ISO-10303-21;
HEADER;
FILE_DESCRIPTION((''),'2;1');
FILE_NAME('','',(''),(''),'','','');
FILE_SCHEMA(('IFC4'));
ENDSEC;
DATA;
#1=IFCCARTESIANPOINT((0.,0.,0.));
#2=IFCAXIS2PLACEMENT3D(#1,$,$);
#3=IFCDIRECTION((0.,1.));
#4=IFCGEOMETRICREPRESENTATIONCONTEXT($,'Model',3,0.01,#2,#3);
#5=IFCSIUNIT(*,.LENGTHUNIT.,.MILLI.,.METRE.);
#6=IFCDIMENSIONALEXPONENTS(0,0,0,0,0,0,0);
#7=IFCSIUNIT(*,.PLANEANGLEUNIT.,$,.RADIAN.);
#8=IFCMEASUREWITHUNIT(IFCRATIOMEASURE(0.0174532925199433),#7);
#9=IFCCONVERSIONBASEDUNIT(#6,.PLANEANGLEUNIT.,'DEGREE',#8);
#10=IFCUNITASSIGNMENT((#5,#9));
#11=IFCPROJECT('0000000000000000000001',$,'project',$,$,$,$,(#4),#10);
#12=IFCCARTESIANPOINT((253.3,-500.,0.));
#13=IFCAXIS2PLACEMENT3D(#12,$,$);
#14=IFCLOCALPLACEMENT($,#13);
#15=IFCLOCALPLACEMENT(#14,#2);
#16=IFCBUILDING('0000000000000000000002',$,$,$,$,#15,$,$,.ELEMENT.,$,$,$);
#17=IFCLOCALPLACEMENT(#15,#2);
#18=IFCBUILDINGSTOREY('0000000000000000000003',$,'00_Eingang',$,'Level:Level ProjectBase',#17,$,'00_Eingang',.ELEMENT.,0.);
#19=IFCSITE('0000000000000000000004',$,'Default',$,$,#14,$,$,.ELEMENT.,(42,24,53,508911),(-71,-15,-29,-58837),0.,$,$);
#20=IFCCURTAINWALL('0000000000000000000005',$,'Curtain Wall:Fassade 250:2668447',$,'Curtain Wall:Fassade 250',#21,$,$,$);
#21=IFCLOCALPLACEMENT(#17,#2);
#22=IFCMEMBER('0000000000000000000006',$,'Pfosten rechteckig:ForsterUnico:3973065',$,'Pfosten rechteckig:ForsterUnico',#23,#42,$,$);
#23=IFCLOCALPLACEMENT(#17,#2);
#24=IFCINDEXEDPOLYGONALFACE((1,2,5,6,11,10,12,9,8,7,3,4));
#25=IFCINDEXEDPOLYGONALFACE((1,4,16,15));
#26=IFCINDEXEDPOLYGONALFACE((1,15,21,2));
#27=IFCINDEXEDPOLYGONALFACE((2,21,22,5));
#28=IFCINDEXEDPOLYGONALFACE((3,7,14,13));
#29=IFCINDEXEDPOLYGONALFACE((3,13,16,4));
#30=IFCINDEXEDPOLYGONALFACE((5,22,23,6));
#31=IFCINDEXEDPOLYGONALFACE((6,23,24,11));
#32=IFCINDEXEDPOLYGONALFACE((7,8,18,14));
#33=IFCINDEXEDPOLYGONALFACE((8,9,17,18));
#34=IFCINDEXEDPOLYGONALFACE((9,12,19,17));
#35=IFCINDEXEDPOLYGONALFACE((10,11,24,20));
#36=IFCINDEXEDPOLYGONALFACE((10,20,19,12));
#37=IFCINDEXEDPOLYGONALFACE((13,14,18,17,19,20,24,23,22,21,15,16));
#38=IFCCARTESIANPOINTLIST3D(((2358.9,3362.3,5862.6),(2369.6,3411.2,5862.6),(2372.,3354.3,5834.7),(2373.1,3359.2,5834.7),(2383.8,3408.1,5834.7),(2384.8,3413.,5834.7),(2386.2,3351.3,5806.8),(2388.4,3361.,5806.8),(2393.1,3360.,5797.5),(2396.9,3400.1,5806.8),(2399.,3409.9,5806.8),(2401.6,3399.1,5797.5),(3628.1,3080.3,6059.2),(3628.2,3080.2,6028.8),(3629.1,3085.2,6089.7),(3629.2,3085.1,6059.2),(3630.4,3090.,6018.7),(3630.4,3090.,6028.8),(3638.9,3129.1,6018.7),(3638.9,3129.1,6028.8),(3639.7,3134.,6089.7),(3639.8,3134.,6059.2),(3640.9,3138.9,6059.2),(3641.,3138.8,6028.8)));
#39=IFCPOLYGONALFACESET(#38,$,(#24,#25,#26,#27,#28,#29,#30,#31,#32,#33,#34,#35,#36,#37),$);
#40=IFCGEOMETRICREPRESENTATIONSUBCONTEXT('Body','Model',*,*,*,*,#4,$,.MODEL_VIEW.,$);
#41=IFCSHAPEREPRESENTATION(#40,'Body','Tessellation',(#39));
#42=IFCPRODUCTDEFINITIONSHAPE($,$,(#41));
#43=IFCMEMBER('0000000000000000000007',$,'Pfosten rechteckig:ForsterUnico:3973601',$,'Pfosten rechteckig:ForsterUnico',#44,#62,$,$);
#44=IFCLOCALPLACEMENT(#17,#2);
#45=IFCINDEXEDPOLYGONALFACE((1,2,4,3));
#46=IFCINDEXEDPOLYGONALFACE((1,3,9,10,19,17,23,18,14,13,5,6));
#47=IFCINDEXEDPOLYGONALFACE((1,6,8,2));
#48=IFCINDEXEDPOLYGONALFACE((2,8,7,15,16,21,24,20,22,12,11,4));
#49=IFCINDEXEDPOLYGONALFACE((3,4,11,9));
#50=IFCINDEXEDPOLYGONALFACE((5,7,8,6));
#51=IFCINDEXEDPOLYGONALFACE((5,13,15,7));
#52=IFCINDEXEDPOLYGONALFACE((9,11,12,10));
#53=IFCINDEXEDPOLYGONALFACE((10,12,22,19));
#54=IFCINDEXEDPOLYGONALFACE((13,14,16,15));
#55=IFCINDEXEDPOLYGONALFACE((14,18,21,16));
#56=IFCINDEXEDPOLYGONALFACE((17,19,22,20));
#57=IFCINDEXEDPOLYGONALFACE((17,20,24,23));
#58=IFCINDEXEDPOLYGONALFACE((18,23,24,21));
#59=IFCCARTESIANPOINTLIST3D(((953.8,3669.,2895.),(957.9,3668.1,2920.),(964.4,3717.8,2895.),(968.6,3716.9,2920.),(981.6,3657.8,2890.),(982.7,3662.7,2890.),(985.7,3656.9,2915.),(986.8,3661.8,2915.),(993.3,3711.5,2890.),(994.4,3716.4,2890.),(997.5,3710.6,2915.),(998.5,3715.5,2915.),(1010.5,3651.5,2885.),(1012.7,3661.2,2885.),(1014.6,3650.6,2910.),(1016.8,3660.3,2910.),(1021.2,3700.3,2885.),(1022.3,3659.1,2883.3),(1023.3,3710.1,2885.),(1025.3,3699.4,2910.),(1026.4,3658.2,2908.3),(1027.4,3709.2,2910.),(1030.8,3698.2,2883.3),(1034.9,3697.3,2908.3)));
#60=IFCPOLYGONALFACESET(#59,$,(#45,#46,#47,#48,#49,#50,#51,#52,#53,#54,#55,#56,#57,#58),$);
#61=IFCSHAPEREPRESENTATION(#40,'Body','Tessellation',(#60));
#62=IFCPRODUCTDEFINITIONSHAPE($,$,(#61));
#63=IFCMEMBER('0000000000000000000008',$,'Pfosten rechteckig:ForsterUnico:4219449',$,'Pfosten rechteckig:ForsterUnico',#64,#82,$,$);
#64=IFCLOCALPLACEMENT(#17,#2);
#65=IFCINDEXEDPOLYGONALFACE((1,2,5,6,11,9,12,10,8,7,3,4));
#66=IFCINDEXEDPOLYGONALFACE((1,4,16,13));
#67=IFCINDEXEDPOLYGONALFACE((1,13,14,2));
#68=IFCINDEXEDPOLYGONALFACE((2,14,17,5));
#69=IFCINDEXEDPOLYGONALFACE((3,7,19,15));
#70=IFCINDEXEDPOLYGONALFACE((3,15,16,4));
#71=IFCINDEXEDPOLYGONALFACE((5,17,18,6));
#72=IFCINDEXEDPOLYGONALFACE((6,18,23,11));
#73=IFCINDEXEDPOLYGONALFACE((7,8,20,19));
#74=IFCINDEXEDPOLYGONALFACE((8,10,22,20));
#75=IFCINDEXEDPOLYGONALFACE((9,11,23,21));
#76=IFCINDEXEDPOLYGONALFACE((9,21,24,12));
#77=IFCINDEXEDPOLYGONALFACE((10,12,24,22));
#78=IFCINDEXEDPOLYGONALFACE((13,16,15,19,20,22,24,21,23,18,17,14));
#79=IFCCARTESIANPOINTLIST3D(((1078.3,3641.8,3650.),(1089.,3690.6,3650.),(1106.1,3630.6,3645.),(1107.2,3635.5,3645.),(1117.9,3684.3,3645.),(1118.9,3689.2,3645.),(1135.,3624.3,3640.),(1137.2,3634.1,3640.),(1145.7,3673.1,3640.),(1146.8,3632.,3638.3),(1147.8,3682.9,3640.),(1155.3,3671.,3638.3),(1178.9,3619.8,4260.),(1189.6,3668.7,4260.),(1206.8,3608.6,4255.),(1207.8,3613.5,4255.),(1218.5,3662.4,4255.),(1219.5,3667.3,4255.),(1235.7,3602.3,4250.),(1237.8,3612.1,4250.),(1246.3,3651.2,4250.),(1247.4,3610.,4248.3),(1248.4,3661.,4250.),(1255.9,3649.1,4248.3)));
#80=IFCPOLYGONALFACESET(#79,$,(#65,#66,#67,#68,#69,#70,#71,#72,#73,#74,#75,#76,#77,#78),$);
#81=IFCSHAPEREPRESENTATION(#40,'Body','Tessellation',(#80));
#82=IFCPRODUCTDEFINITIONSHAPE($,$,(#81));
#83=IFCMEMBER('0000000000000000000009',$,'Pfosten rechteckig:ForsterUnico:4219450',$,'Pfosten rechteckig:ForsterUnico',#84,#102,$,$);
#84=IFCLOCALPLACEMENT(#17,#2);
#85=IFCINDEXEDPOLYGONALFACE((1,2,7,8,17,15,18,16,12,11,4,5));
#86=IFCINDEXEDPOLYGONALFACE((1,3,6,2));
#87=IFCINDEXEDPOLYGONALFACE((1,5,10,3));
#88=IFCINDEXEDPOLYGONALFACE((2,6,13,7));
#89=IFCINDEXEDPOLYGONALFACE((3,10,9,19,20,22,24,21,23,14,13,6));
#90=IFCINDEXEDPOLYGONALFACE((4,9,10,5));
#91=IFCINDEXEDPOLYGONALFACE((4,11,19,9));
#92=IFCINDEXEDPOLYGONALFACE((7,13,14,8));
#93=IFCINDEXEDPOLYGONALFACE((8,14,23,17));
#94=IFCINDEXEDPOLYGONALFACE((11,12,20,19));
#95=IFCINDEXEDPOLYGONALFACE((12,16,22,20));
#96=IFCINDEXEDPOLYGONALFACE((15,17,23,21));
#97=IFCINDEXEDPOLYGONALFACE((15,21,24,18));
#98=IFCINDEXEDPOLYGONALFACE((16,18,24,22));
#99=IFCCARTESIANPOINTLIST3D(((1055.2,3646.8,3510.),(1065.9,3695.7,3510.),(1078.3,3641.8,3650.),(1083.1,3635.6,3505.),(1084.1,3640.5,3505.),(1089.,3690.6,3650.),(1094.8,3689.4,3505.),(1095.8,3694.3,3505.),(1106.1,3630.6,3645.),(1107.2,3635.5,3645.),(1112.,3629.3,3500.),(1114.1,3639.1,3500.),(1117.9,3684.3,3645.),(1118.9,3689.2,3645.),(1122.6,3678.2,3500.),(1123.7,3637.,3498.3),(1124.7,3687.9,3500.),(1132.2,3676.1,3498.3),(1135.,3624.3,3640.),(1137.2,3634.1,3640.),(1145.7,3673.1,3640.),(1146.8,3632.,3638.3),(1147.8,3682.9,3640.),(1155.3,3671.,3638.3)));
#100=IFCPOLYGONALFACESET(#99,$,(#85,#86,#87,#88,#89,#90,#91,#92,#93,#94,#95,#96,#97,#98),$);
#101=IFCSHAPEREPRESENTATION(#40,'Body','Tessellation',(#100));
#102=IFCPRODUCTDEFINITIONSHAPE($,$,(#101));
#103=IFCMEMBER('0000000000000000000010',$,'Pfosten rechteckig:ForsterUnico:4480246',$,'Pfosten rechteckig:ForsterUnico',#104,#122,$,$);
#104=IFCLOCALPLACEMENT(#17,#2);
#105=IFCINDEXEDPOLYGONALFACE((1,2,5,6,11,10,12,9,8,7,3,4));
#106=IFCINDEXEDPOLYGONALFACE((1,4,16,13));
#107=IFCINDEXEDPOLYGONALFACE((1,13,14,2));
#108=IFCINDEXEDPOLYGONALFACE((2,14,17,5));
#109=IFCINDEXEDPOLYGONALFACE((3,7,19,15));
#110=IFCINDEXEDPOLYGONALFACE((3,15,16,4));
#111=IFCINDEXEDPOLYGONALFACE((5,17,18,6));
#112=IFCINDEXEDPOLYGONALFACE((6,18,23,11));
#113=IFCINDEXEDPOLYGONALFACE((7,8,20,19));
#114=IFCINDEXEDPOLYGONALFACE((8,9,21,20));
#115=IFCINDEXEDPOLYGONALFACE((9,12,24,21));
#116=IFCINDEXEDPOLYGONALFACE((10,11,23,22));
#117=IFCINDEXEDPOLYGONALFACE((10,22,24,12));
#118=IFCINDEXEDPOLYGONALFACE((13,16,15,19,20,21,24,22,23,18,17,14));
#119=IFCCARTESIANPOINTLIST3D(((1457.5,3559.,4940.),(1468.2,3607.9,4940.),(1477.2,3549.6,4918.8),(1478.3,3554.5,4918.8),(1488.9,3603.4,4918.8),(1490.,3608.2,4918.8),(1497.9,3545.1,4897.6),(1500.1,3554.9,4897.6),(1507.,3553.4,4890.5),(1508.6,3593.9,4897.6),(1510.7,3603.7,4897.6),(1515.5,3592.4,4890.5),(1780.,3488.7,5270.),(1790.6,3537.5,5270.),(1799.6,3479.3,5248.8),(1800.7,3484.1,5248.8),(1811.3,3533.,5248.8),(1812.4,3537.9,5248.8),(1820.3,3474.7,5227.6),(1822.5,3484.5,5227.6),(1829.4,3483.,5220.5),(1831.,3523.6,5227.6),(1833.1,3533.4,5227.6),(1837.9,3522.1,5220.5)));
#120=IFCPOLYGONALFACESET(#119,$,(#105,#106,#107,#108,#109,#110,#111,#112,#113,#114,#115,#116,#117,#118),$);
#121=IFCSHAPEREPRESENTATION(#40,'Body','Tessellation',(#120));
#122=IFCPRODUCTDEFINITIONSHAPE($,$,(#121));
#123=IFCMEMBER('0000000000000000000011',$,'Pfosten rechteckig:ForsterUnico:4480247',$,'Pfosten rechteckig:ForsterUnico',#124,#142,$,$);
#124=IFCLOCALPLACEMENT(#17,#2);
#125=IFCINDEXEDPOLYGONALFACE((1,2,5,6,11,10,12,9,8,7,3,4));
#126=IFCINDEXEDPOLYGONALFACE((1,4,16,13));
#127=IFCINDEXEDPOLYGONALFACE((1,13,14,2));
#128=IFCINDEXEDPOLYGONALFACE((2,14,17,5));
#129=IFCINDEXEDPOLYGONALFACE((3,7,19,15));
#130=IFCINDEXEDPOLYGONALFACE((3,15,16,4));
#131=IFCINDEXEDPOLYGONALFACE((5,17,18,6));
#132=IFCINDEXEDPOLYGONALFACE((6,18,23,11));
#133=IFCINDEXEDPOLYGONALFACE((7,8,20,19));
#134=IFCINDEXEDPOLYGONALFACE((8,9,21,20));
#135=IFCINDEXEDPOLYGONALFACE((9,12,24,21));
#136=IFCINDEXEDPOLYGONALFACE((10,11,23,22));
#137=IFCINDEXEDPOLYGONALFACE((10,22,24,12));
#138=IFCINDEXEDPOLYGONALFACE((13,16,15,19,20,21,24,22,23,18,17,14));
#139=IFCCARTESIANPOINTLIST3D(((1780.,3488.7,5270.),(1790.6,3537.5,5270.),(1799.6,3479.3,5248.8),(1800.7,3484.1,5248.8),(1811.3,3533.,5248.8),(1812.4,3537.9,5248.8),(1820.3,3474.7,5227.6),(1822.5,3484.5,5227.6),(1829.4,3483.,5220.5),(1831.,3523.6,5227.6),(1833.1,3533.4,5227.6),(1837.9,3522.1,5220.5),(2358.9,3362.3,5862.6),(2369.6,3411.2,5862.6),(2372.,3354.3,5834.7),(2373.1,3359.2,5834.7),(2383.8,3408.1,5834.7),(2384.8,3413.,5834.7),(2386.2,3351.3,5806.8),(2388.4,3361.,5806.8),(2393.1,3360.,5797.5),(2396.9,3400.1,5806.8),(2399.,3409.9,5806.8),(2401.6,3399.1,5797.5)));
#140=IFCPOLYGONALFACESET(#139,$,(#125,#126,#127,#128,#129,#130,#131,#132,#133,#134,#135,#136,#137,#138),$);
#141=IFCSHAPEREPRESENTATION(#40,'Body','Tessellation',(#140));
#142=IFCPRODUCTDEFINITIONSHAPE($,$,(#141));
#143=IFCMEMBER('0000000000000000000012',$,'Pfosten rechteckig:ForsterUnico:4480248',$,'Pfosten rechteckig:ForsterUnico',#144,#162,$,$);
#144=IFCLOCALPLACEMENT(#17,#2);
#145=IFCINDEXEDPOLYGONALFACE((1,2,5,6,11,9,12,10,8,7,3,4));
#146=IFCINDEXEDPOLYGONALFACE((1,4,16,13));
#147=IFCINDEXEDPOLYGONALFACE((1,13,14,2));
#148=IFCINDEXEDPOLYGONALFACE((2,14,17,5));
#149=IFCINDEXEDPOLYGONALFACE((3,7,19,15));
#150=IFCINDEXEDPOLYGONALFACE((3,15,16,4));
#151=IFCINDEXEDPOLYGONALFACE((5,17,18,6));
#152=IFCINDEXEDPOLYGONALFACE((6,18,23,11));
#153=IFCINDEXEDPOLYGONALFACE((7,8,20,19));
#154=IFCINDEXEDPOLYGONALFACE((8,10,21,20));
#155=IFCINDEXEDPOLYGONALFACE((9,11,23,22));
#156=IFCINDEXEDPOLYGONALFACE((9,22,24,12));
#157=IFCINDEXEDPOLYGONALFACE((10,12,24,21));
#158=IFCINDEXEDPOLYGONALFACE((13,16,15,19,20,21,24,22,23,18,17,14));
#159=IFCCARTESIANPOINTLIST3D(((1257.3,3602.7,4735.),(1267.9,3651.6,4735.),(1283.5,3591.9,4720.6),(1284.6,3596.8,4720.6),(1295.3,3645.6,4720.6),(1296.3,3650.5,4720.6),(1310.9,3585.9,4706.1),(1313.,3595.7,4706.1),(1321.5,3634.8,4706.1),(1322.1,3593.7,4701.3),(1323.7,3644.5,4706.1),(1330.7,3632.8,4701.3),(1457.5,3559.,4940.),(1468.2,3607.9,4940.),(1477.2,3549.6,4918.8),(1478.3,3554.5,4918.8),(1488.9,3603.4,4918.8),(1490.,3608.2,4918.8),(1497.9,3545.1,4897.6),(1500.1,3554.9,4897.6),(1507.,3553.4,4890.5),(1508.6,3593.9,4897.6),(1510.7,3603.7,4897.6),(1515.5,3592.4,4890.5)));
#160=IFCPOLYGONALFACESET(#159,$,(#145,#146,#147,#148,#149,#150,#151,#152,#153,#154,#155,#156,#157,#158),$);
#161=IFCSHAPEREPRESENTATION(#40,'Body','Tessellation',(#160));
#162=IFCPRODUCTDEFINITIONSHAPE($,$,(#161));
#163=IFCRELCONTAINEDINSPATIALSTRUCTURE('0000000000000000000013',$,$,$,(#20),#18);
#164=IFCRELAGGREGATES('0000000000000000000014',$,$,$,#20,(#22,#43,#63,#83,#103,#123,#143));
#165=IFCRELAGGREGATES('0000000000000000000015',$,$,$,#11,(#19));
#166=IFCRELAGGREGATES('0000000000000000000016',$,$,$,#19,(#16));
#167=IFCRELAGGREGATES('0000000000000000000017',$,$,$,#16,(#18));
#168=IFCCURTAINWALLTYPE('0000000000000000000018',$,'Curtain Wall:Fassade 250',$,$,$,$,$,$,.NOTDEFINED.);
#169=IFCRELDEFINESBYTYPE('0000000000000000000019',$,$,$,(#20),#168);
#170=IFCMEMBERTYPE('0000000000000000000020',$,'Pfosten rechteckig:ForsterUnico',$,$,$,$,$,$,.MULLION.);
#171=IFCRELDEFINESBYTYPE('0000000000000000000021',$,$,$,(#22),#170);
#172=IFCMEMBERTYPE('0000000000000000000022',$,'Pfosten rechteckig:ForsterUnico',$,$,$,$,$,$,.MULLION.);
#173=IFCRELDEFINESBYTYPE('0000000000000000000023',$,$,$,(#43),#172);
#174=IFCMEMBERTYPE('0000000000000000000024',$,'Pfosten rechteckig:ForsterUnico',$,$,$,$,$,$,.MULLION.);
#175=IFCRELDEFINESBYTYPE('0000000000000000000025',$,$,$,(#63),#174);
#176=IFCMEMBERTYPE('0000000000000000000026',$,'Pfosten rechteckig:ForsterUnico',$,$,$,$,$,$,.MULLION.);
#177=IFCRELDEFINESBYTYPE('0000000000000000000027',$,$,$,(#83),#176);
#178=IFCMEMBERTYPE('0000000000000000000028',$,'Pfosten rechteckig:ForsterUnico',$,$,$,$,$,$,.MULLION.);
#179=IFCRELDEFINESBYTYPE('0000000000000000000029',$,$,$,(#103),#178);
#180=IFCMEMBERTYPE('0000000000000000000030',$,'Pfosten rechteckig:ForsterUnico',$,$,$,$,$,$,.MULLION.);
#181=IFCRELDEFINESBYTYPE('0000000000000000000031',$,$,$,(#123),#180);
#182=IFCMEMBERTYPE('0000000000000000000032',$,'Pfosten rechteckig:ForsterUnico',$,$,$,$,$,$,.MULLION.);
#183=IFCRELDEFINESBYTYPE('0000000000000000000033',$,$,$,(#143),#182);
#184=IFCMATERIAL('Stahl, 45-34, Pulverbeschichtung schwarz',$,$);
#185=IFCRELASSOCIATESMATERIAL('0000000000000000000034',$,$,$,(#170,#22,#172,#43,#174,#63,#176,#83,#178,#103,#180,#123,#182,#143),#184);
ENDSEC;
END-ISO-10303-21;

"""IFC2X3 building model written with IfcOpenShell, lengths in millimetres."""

from ifc_helpers import new_model, entity, si_unit, converted_unit, direction, frame, origin, place, context, subcontext, project, spatial, polyline, outline, extrude, clip, halfspace, source, transform, mapped, material, type_object, type_shapes, element, aggregate, save


model = new_model("IFC2X3")

# Units and contexts
model_context = context("Model", 3, precision=0.01, world=origin(), true_north=direction((0.0, 1.0)))
body_context = subcontext(model_context, "Body", "Model", "MODEL_VIEW")
ifc_project = project(units=[si_unit("LENGTHUNIT", "METRE", prefix="MILLI"), converted_unit("PLANEANGLEUNIT", "DEGREE", entity("IfcRatioMeasure", 0.0174532925199433), si_unit("PLANEANGLEUNIT", "RADIAN"), dimensions=[0, 0, 0, 0, 0, 0, 0])], contexts=[model_context])

# Site, building, storey
site_placement = place(None, frame((253.3, -500.0, 0.0)))
site = spatial("IfcSite", under=ifc_project, at=site_placement, Name="Default", CompositionType="ELEMENT", RefLatitude=(42, 24, 53, 508911), RefLongitude=(-71, -15, -29, -58837), RefElevation=0.0)
building_placement = place(site_placement, origin())
building = spatial("IfcBuilding", under=site, at=building_placement, CompositionType="ELEMENT")
storey_placement = place(building_placement, origin())
storey = spatial("IfcBuildingStorey", under=building, at=storey_placement, Name="00_Eingang", ObjectType="Level:Level ProjectBase", LongName="00_Eingang", CompositionType="ELEMENT", Elevation=0.0)

# Curtain wall, members
curtain_wall_type = type_object("IfcCurtainWallType", Name="Curtain Wall:Fassade 250", PredefinedType="NOTDEFINED")
curtain_wall_placement = place(storey_placement, origin())
curtain_wall = element("IfcCurtainWall", 1, at=curtain_wall_placement, inside=storey, type_object=curtain_wall_type, Name="Curtain Wall:Fassade 250:2668447", ObjectType="Curtain Wall:Fassade 250")
ifc_material_1 = material(Name="Stahl, 45-34, Pulverbeschichtung schwarz")
member_type_1 = type_object("IfcMemberType", Name="Pfosten rechteckig:ForsterUnico", PredefinedType="MULLION", material=ifc_material_1)
shared_shape_1 = source(origin(), body_context, "Body", "Clipping", [
    clip(clip(extrude(outline(polyline([(-20.0, -28.3), (20.0, -28.3), (20.0, -18.3), (30.0, -18.3), (30.0, 11.7), (25.0, 11.7), (25.0, 41.7), (-25.0, 41.7), (-25.0, 11.7), (-30.0, 11.7), (-30.0, -18.3), (-20.0, -18.3), (-20.0, -28.3)])), frame((-41.7, 0.0, -1319.7), z_axis=(0.0, 0.0, 1.0), x_axis=(0.0, -1.0, 0.0)), (0.0, 0.0, 1.0), 1319.7), halfspace(frame((0.0, -304.8, -1319.7), z_axis=(-0.167911, 0.0, -0.985802), x_axis=(-0.985802, 0.0, 0.167911)), False)), halfspace(frame((0.0, -304.8, 0.0), z_axis=(-0.301476, 0.0, 0.953474), x_axis=(-0.953474, 0.0, -0.301476)), False)),
])
type_shapes(member_type_1, [shared_shape_1])
member_1_placement = place(storey_placement, frame((2364.3, 3386.8, 5862.6), z_axis=(-0.962438, 0.210021, -0.172057), x_axis=(-0.168101, 0.036683, 0.985087)))
member_1 = element("IfcMember", 2, at=member_1_placement, type_object=member_type_1, material=ifc_material_1, Name="Pfosten rechteckig:ForsterUnico:3973065", ObjectType="Pfosten rechteckig:ForsterUnico", context=body_context, shape_type="MappedRepresentation", body=[
    mapped(shared_shape_1, transform((0.0, 0.0, 0.0), scale=1.0)),
])
member_type_2 = type_object("IfcMemberType", Name="Pfosten rechteckig:ForsterUnico", PredefinedType="MULLION", material=ifc_material_1)
shared_shape_2 = source(origin(), body_context, "Body", "SweptSolid", [
    extrude(outline(polyline([(-20.0, -28.3), (20.0, -28.3), (20.0, -18.3), (30.0, -18.3), (30.0, 11.7), (25.0, 11.7), (25.0, 41.7), (-25.0, 41.7), (-25.0, 11.7), (-30.0, 11.7), (-30.0, -18.3), (-20.0, -18.3), (-20.0, -28.3)])), frame((-41.7, 0.0, -25.4), z_axis=(0.0, 0.0, 1.0), x_axis=(0.0, -1.0, 0.0)), (0.0, 0.0, 1.0), 25.4),
])
type_shapes(member_type_2, [shared_shape_2])
member_2_placement = place(storey_placement, frame((959.1, 3693.4, 2895.0), z_axis=(-0.162632, 0.035489, -0.986048), x_axis=(-0.963377, 0.210226, 0.16646)))
member_2 = element("IfcMember", 3, at=member_2_placement, type_object=member_type_2, material=ifc_material_1, Name="Pfosten rechteckig:ForsterUnico:3973601", ObjectType="Pfosten rechteckig:ForsterUnico", context=body_context, shape_type="MappedRepresentation", body=[
    mapped(shared_shape_2, transform((0.0, 0.0, 0.0), scale=1.0)),
])
member_type_3 = type_object("IfcMemberType", Name="Pfosten rechteckig:ForsterUnico", PredefinedType="MULLION", material=ifc_material_1)
shared_shape_3 = source(origin(), body_context, "Body", "SweptSolid", [
    extrude(outline(polyline([(-20.0, -28.3), (20.0, -28.3), (20.0, -18.3), (30.0, -18.3), (30.0, 11.7), (25.0, 11.7), (25.0, 41.7), (-25.0, 41.7), (-25.0, 11.7), (-30.0, 11.7), (-30.0, -18.3), (-20.0, -18.3), (-20.0, -28.3)])), frame((-41.7, 0.0, -618.6), z_axis=(0.0, 0.0, 1.0), x_axis=(0.0, -1.0, 0.0)), (0.0, 0.0, 1.0), 618.6),
])
type_shapes(member_type_3, [shared_shape_3])
member_3_placement = place(storey_placement, frame((1083.6, 3666.2, 3650.0), z_axis=(-0.162632, 0.035489, -0.986048), x_axis=(-0.963377, 0.210226, 0.16646)))
member_3 = element("IfcMember", 4, at=member_3_placement, type_object=member_type_3, material=ifc_material_1, Name="Pfosten rechteckig:ForsterUnico:4219449", ObjectType="Pfosten rechteckig:ForsterUnico", context=body_context, shape_type="MappedRepresentation", body=[
    mapped(shared_shape_3, transform((0.0, 0.0, 0.0), scale=1.0)),
])
member_type_4 = type_object("IfcMemberType", Name="Pfosten rechteckig:ForsterUnico", PredefinedType="MULLION", material=ifc_material_1)
shared_shape_4 = source(origin(), body_context, "Body", "SweptSolid", [
    extrude(outline(polyline([(-20.0, -28.3), (20.0, -28.3), (20.0, -18.3), (30.0, -18.3), (30.0, 11.7), (25.0, 11.7), (25.0, 41.7), (-25.0, 41.7), (-25.0, 11.7), (-30.0, 11.7), (-30.0, -18.3), (-20.0, -18.3), (-20.0, -28.3)])), frame((-41.7, 0.0, -142.0), z_axis=(0.0, 0.0, 1.0), x_axis=(0.0, -1.0, 0.0)), (0.0, 0.0, 1.0), 142.0),
])
type_shapes(member_type_4, [shared_shape_4])
member_4_placement = place(storey_placement, frame((1060.5, 3671.2, 3510.0), z_axis=(-0.162632, 0.035489, -0.986048), x_axis=(-0.963377, 0.210226, 0.16646)))
member_4 = element("IfcMember", 5, at=member_4_placement, type_object=member_type_4, material=ifc_material_1, Name="Pfosten rechteckig:ForsterUnico:4219450", ObjectType="Pfosten rechteckig:ForsterUnico", context=body_context, shape_type="MappedRepresentation", body=[
    mapped(shared_shape_4, transform((0.0, 0.0, 0.0), scale=1.0)),
])
member_type_5 = type_object("IfcMemberType", Name="Pfosten rechteckig:ForsterUnico", PredefinedType="MULLION", material=ifc_material_1)
shared_shape_5 = source(origin(), body_context, "Body", "SweptSolid", [
    extrude(outline(polyline([(-20.0, -28.3), (20.0, -28.3), (20.0, -18.3), (30.0, -18.3), (30.0, 11.7), (25.0, 11.7), (25.0, 41.7), (-25.0, 41.7), (-25.0, 11.7), (-30.0, 11.7), (-30.0, -18.3), (-20.0, -18.3), (-20.0, -28.3)])), frame((-41.7, 0.0, -466.7), z_axis=(0.0, 0.0, 1.0), x_axis=(0.0, -1.0, 0.0)), (0.0, 0.0, 1.0), 466.7),
])
type_shapes(member_type_5, [shared_shape_5])
member_5_placement = place(storey_placement, frame((1462.9, 3583.5, 4940.0), z_axis=(-0.690849, 0.150756, -0.707107), x_axis=(-0.690849, 0.150756, 0.707107)))
member_5 = element("IfcMember", 6, at=member_5_placement, type_object=member_type_5, material=ifc_material_1, Name="Pfosten rechteckig:ForsterUnico:4480246", ObjectType="Pfosten rechteckig:ForsterUnico", context=body_context, shape_type="MappedRepresentation", body=[
    mapped(shared_shape_5, transform((0.0, 0.0, 0.0), scale=1.0)),
])
member_type_6 = type_object("IfcMemberType", Name="Pfosten rechteckig:ForsterUnico", PredefinedType="MULLION", material=ifc_material_1)
shared_shape_6 = source(origin(), body_context, "Body", "Clipping", [
    clip(extrude(outline(polyline([(-20.0, -28.3), (20.0, -28.3), (20.0, -18.3), (30.0, -18.3), (30.0, 11.7), (25.0, 11.7), (25.0, 41.7), (-25.0, 41.7), (-25.0, 11.7), (-30.0, 11.7), (-30.0, -18.3), (-20.0, -18.3), (-20.0, -28.3)])), frame((-41.7, 0.0, -838.1), z_axis=(0.0, 0.0, 1.0), x_axis=(0.0, -1.0, 0.0)), (0.0, 0.0, 1.0), 838.1), halfspace(frame((0.0, -304.8, -838.1), z_axis=(-0.301476, 0.0, -0.953474), x_axis=(-0.953474, 0.0, 0.301476)), False)),
])
type_shapes(member_type_6, [shared_shape_6])
member_6_placement = place(storey_placement, frame((1785.3, 3513.1, 5270.0), z_axis=(-0.690849, 0.150756, -0.707107), x_axis=(-0.690849, 0.150756, 0.707107)))
member_6 = element("IfcMember", 7, at=member_6_placement, type_object=member_type_6, material=ifc_material_1, Name="Pfosten rechteckig:ForsterUnico:4480247", ObjectType="Pfosten rechteckig:ForsterUnico", context=body_context, shape_type="MappedRepresentation", body=[
    mapped(shared_shape_6, transform((0.0, 0.0, 0.0), scale=1.0)),
])
member_type_7 = type_object("IfcMemberType", Name="Pfosten rechteckig:ForsterUnico", PredefinedType="MULLION", material=ifc_material_1)
shared_shape_7 = source(origin(), body_context, "Body", "Clipping", [
    clip(extrude(outline(polyline([(-20.0, -28.3), (20.0, -28.3), (20.0, -18.3), (30.0, -18.3), (30.0, 11.7), (25.0, 11.7), (25.0, 41.7), (-25.0, 41.7), (-25.0, 11.7), (-30.0, 11.7), (-30.0, -18.3), (-20.0, -18.3), (-20.0, -28.3)])), frame((-41.7, 0.0, -289.9), z_axis=(0.0, 0.0, 1.0), x_axis=(0.0, -1.0, 0.0)), (0.0, 0.0, 1.0), 289.9), halfspace(frame((0.0, -304.8, 0.0), z_axis=(-0.304182, 0.0, 0.952614), x_axis=(-0.952614, 0.0, -0.304182)), False)),
])
type_shapes(member_type_7, [shared_shape_7])
member_7_placement = place(storey_placement, frame((1262.6, 3627.2, 4735.0), z_axis=(-0.690849, 0.150756, -0.707107), x_axis=(-0.690849, 0.150756, 0.707107)))
member_7 = element("IfcMember", 8, at=member_7_placement, type_object=member_type_7, material=ifc_material_1, Name="Pfosten rechteckig:ForsterUnico:4480248", ObjectType="Pfosten rechteckig:ForsterUnico", context=body_context, shape_type="MappedRepresentation", body=[
    mapped(shared_shape_7, transform((0.0, 0.0, 0.0), scale=1.0)),
])
aggregate(curtain_wall, [member_1, member_2, member_3, member_4, member_5, member_6, member_7])

save(model, "model.ifc")
